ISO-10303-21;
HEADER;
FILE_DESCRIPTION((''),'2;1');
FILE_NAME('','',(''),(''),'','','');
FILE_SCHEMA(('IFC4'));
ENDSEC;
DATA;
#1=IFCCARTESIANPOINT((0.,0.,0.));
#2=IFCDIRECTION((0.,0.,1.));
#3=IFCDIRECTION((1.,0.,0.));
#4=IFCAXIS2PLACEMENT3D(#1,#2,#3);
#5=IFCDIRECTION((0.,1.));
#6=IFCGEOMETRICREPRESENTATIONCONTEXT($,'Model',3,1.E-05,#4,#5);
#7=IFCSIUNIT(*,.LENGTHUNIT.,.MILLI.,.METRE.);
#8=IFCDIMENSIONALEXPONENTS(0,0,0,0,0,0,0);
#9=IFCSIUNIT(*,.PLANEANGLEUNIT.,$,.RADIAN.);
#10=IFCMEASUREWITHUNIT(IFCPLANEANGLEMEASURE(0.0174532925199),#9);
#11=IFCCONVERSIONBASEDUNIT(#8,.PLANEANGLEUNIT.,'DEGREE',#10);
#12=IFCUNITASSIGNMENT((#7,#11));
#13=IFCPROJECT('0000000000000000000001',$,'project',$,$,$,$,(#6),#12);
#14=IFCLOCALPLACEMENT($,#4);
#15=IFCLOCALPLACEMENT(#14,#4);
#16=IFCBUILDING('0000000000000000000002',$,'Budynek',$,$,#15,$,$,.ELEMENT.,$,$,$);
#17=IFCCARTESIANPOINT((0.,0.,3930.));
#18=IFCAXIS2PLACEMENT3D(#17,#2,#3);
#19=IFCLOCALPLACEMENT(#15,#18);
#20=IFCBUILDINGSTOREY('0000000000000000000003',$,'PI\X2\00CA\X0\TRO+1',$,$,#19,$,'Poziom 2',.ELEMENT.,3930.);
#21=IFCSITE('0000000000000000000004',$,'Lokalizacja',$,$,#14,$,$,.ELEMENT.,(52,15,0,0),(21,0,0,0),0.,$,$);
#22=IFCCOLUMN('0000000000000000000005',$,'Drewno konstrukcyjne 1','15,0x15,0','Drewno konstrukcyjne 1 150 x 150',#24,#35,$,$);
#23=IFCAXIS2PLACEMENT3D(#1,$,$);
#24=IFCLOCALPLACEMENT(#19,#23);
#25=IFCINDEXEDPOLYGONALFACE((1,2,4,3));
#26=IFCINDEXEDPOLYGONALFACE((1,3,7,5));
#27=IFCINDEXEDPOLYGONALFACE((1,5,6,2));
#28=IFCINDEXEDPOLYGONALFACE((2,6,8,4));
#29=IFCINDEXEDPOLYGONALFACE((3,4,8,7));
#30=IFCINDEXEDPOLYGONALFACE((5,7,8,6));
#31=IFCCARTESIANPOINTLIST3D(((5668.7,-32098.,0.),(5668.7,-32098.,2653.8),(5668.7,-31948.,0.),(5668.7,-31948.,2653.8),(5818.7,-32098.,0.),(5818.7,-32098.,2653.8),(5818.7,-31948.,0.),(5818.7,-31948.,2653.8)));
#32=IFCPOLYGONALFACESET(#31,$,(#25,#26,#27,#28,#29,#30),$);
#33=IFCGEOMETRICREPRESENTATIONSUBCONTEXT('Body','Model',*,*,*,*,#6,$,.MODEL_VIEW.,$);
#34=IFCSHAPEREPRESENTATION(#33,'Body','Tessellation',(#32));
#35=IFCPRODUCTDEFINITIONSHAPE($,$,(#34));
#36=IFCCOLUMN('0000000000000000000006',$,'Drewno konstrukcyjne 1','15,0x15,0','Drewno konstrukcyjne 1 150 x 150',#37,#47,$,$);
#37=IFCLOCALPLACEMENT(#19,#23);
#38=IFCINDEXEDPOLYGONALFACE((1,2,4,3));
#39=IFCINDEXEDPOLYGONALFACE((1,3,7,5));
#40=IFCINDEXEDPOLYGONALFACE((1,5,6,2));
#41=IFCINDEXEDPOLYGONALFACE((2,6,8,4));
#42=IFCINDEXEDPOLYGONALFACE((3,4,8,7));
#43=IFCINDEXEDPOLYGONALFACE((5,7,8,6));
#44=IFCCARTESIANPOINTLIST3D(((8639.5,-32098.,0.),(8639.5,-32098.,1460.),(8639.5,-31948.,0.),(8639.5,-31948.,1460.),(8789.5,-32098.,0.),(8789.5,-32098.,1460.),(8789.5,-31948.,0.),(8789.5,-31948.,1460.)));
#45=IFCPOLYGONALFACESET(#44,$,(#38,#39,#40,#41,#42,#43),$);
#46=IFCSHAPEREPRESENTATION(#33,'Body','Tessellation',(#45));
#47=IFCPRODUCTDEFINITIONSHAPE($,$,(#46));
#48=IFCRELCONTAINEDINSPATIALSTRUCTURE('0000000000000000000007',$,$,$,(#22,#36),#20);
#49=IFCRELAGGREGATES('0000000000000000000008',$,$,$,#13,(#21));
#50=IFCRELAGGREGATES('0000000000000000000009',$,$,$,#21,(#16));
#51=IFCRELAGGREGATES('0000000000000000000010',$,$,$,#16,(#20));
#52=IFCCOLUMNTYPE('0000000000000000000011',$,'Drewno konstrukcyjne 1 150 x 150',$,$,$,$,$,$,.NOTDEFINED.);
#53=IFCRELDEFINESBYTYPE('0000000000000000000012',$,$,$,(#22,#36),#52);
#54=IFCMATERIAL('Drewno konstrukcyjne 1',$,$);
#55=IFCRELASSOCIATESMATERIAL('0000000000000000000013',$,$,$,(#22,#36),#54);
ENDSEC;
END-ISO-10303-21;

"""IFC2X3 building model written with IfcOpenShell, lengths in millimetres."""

from ifc_helpers import new_model, entity, si_unit, converted_unit, direction, frame, origin_with_axes, origin_2d_with_axis, place, context, subcontext, project, spatial, rectangle, extrude, material, type_object, element, save


model = new_model("IFC2X3")

# Units and contexts
model_context = context("Model", 3, precision=1e-05, world=origin_with_axes(), true_north=direction((0.0, 1.0)))
body_context = subcontext(model_context, "Body", "Model", "MODEL_VIEW")
ifc_project = project(units=[si_unit("LENGTHUNIT", "METRE", prefix="MILLI"), converted_unit("PLANEANGLEUNIT", "DEGREE", entity("IfcPlaneAngleMeasure", 0.0174532925199), si_unit("PLANEANGLEUNIT", "RADIAN"), dimensions=[0, 0, 0, 0, 0, 0, 0])], contexts=[model_context])

# Site, building, storey
site_placement = place(None, origin_with_axes())
site = spatial("IfcSite", under=ifc_project, at=site_placement, Name="Lokalizacja", CompositionType="ELEMENT", RefLatitude=(52, 15, 0, 0), RefLongitude=(21, 0, 0, 0), RefElevation=0.0)
building_placement = place(site_placement, origin_with_axes())
building = spatial("IfcBuilding", under=site, at=building_placement, Name="Budynek", CompositionType="ELEMENT")
storey_placement = place(building_placement, frame((0.0, 0.0, 3930.0), z_axis=(0.0, 0.0, 1.0), x_axis=(1.0, 0.0, 0.0)))
storey = spatial("IfcBuildingStorey", under=building, at=storey_placement, Name="PIÊTRO+1", LongName="Poziom 2", CompositionType="ELEMENT", Elevation=3930.0)

# Columns
ifc_material_1 = material(Name="Drewno konstrukcyjne 1")
column_type = type_object("IfcColumnType", Name="Drewno konstrukcyjne 1 150 x 150", PredefinedType="NOTDEFINED")
column_1_placement = place(storey_placement, frame((5743.7, -32023.0, 0.0), z_axis=(0.0, 0.0, 1.0), x_axis=(1.0, 0.0, 0.0)))
element("IfcColumn", 1, at=column_1_placement, inside=storey, type_object=column_type, material=ifc_material_1, Name="Drewno konstrukcyjne 1", Description="15,0x15,0", ObjectType="Drewno konstrukcyjne 1 150 x 150", context=body_context, shape_type="SweptSolid", body=[
    extrude(rectangle(XDim=150.0, YDim=150.0, at=origin_2d_with_axis()), origin_with_axes(), (0.0, 0.0, 1.0), 2653.8),
])
column_2_placement = place(storey_placement, frame((8714.5, -32023.0, 0.0), z_axis=(0.0, 0.0, 1.0), x_axis=(1.0, 0.0, 0.0)))
element("IfcColumn", 2, at=column_2_placement, inside=storey, type_object=column_type, material=ifc_material_1, Name="Drewno konstrukcyjne 1", Description="15,0x15,0", ObjectType="Drewno konstrukcyjne 1 150 x 150", context=body_context, shape_type="SweptSolid", body=[
    extrude(rectangle(XDim=150.0, YDim=150.0, at=origin_2d_with_axis()), origin_with_axes(), (0.0, 0.0, 1.0), 1460.0),
])

save(model, "model.ifc")
